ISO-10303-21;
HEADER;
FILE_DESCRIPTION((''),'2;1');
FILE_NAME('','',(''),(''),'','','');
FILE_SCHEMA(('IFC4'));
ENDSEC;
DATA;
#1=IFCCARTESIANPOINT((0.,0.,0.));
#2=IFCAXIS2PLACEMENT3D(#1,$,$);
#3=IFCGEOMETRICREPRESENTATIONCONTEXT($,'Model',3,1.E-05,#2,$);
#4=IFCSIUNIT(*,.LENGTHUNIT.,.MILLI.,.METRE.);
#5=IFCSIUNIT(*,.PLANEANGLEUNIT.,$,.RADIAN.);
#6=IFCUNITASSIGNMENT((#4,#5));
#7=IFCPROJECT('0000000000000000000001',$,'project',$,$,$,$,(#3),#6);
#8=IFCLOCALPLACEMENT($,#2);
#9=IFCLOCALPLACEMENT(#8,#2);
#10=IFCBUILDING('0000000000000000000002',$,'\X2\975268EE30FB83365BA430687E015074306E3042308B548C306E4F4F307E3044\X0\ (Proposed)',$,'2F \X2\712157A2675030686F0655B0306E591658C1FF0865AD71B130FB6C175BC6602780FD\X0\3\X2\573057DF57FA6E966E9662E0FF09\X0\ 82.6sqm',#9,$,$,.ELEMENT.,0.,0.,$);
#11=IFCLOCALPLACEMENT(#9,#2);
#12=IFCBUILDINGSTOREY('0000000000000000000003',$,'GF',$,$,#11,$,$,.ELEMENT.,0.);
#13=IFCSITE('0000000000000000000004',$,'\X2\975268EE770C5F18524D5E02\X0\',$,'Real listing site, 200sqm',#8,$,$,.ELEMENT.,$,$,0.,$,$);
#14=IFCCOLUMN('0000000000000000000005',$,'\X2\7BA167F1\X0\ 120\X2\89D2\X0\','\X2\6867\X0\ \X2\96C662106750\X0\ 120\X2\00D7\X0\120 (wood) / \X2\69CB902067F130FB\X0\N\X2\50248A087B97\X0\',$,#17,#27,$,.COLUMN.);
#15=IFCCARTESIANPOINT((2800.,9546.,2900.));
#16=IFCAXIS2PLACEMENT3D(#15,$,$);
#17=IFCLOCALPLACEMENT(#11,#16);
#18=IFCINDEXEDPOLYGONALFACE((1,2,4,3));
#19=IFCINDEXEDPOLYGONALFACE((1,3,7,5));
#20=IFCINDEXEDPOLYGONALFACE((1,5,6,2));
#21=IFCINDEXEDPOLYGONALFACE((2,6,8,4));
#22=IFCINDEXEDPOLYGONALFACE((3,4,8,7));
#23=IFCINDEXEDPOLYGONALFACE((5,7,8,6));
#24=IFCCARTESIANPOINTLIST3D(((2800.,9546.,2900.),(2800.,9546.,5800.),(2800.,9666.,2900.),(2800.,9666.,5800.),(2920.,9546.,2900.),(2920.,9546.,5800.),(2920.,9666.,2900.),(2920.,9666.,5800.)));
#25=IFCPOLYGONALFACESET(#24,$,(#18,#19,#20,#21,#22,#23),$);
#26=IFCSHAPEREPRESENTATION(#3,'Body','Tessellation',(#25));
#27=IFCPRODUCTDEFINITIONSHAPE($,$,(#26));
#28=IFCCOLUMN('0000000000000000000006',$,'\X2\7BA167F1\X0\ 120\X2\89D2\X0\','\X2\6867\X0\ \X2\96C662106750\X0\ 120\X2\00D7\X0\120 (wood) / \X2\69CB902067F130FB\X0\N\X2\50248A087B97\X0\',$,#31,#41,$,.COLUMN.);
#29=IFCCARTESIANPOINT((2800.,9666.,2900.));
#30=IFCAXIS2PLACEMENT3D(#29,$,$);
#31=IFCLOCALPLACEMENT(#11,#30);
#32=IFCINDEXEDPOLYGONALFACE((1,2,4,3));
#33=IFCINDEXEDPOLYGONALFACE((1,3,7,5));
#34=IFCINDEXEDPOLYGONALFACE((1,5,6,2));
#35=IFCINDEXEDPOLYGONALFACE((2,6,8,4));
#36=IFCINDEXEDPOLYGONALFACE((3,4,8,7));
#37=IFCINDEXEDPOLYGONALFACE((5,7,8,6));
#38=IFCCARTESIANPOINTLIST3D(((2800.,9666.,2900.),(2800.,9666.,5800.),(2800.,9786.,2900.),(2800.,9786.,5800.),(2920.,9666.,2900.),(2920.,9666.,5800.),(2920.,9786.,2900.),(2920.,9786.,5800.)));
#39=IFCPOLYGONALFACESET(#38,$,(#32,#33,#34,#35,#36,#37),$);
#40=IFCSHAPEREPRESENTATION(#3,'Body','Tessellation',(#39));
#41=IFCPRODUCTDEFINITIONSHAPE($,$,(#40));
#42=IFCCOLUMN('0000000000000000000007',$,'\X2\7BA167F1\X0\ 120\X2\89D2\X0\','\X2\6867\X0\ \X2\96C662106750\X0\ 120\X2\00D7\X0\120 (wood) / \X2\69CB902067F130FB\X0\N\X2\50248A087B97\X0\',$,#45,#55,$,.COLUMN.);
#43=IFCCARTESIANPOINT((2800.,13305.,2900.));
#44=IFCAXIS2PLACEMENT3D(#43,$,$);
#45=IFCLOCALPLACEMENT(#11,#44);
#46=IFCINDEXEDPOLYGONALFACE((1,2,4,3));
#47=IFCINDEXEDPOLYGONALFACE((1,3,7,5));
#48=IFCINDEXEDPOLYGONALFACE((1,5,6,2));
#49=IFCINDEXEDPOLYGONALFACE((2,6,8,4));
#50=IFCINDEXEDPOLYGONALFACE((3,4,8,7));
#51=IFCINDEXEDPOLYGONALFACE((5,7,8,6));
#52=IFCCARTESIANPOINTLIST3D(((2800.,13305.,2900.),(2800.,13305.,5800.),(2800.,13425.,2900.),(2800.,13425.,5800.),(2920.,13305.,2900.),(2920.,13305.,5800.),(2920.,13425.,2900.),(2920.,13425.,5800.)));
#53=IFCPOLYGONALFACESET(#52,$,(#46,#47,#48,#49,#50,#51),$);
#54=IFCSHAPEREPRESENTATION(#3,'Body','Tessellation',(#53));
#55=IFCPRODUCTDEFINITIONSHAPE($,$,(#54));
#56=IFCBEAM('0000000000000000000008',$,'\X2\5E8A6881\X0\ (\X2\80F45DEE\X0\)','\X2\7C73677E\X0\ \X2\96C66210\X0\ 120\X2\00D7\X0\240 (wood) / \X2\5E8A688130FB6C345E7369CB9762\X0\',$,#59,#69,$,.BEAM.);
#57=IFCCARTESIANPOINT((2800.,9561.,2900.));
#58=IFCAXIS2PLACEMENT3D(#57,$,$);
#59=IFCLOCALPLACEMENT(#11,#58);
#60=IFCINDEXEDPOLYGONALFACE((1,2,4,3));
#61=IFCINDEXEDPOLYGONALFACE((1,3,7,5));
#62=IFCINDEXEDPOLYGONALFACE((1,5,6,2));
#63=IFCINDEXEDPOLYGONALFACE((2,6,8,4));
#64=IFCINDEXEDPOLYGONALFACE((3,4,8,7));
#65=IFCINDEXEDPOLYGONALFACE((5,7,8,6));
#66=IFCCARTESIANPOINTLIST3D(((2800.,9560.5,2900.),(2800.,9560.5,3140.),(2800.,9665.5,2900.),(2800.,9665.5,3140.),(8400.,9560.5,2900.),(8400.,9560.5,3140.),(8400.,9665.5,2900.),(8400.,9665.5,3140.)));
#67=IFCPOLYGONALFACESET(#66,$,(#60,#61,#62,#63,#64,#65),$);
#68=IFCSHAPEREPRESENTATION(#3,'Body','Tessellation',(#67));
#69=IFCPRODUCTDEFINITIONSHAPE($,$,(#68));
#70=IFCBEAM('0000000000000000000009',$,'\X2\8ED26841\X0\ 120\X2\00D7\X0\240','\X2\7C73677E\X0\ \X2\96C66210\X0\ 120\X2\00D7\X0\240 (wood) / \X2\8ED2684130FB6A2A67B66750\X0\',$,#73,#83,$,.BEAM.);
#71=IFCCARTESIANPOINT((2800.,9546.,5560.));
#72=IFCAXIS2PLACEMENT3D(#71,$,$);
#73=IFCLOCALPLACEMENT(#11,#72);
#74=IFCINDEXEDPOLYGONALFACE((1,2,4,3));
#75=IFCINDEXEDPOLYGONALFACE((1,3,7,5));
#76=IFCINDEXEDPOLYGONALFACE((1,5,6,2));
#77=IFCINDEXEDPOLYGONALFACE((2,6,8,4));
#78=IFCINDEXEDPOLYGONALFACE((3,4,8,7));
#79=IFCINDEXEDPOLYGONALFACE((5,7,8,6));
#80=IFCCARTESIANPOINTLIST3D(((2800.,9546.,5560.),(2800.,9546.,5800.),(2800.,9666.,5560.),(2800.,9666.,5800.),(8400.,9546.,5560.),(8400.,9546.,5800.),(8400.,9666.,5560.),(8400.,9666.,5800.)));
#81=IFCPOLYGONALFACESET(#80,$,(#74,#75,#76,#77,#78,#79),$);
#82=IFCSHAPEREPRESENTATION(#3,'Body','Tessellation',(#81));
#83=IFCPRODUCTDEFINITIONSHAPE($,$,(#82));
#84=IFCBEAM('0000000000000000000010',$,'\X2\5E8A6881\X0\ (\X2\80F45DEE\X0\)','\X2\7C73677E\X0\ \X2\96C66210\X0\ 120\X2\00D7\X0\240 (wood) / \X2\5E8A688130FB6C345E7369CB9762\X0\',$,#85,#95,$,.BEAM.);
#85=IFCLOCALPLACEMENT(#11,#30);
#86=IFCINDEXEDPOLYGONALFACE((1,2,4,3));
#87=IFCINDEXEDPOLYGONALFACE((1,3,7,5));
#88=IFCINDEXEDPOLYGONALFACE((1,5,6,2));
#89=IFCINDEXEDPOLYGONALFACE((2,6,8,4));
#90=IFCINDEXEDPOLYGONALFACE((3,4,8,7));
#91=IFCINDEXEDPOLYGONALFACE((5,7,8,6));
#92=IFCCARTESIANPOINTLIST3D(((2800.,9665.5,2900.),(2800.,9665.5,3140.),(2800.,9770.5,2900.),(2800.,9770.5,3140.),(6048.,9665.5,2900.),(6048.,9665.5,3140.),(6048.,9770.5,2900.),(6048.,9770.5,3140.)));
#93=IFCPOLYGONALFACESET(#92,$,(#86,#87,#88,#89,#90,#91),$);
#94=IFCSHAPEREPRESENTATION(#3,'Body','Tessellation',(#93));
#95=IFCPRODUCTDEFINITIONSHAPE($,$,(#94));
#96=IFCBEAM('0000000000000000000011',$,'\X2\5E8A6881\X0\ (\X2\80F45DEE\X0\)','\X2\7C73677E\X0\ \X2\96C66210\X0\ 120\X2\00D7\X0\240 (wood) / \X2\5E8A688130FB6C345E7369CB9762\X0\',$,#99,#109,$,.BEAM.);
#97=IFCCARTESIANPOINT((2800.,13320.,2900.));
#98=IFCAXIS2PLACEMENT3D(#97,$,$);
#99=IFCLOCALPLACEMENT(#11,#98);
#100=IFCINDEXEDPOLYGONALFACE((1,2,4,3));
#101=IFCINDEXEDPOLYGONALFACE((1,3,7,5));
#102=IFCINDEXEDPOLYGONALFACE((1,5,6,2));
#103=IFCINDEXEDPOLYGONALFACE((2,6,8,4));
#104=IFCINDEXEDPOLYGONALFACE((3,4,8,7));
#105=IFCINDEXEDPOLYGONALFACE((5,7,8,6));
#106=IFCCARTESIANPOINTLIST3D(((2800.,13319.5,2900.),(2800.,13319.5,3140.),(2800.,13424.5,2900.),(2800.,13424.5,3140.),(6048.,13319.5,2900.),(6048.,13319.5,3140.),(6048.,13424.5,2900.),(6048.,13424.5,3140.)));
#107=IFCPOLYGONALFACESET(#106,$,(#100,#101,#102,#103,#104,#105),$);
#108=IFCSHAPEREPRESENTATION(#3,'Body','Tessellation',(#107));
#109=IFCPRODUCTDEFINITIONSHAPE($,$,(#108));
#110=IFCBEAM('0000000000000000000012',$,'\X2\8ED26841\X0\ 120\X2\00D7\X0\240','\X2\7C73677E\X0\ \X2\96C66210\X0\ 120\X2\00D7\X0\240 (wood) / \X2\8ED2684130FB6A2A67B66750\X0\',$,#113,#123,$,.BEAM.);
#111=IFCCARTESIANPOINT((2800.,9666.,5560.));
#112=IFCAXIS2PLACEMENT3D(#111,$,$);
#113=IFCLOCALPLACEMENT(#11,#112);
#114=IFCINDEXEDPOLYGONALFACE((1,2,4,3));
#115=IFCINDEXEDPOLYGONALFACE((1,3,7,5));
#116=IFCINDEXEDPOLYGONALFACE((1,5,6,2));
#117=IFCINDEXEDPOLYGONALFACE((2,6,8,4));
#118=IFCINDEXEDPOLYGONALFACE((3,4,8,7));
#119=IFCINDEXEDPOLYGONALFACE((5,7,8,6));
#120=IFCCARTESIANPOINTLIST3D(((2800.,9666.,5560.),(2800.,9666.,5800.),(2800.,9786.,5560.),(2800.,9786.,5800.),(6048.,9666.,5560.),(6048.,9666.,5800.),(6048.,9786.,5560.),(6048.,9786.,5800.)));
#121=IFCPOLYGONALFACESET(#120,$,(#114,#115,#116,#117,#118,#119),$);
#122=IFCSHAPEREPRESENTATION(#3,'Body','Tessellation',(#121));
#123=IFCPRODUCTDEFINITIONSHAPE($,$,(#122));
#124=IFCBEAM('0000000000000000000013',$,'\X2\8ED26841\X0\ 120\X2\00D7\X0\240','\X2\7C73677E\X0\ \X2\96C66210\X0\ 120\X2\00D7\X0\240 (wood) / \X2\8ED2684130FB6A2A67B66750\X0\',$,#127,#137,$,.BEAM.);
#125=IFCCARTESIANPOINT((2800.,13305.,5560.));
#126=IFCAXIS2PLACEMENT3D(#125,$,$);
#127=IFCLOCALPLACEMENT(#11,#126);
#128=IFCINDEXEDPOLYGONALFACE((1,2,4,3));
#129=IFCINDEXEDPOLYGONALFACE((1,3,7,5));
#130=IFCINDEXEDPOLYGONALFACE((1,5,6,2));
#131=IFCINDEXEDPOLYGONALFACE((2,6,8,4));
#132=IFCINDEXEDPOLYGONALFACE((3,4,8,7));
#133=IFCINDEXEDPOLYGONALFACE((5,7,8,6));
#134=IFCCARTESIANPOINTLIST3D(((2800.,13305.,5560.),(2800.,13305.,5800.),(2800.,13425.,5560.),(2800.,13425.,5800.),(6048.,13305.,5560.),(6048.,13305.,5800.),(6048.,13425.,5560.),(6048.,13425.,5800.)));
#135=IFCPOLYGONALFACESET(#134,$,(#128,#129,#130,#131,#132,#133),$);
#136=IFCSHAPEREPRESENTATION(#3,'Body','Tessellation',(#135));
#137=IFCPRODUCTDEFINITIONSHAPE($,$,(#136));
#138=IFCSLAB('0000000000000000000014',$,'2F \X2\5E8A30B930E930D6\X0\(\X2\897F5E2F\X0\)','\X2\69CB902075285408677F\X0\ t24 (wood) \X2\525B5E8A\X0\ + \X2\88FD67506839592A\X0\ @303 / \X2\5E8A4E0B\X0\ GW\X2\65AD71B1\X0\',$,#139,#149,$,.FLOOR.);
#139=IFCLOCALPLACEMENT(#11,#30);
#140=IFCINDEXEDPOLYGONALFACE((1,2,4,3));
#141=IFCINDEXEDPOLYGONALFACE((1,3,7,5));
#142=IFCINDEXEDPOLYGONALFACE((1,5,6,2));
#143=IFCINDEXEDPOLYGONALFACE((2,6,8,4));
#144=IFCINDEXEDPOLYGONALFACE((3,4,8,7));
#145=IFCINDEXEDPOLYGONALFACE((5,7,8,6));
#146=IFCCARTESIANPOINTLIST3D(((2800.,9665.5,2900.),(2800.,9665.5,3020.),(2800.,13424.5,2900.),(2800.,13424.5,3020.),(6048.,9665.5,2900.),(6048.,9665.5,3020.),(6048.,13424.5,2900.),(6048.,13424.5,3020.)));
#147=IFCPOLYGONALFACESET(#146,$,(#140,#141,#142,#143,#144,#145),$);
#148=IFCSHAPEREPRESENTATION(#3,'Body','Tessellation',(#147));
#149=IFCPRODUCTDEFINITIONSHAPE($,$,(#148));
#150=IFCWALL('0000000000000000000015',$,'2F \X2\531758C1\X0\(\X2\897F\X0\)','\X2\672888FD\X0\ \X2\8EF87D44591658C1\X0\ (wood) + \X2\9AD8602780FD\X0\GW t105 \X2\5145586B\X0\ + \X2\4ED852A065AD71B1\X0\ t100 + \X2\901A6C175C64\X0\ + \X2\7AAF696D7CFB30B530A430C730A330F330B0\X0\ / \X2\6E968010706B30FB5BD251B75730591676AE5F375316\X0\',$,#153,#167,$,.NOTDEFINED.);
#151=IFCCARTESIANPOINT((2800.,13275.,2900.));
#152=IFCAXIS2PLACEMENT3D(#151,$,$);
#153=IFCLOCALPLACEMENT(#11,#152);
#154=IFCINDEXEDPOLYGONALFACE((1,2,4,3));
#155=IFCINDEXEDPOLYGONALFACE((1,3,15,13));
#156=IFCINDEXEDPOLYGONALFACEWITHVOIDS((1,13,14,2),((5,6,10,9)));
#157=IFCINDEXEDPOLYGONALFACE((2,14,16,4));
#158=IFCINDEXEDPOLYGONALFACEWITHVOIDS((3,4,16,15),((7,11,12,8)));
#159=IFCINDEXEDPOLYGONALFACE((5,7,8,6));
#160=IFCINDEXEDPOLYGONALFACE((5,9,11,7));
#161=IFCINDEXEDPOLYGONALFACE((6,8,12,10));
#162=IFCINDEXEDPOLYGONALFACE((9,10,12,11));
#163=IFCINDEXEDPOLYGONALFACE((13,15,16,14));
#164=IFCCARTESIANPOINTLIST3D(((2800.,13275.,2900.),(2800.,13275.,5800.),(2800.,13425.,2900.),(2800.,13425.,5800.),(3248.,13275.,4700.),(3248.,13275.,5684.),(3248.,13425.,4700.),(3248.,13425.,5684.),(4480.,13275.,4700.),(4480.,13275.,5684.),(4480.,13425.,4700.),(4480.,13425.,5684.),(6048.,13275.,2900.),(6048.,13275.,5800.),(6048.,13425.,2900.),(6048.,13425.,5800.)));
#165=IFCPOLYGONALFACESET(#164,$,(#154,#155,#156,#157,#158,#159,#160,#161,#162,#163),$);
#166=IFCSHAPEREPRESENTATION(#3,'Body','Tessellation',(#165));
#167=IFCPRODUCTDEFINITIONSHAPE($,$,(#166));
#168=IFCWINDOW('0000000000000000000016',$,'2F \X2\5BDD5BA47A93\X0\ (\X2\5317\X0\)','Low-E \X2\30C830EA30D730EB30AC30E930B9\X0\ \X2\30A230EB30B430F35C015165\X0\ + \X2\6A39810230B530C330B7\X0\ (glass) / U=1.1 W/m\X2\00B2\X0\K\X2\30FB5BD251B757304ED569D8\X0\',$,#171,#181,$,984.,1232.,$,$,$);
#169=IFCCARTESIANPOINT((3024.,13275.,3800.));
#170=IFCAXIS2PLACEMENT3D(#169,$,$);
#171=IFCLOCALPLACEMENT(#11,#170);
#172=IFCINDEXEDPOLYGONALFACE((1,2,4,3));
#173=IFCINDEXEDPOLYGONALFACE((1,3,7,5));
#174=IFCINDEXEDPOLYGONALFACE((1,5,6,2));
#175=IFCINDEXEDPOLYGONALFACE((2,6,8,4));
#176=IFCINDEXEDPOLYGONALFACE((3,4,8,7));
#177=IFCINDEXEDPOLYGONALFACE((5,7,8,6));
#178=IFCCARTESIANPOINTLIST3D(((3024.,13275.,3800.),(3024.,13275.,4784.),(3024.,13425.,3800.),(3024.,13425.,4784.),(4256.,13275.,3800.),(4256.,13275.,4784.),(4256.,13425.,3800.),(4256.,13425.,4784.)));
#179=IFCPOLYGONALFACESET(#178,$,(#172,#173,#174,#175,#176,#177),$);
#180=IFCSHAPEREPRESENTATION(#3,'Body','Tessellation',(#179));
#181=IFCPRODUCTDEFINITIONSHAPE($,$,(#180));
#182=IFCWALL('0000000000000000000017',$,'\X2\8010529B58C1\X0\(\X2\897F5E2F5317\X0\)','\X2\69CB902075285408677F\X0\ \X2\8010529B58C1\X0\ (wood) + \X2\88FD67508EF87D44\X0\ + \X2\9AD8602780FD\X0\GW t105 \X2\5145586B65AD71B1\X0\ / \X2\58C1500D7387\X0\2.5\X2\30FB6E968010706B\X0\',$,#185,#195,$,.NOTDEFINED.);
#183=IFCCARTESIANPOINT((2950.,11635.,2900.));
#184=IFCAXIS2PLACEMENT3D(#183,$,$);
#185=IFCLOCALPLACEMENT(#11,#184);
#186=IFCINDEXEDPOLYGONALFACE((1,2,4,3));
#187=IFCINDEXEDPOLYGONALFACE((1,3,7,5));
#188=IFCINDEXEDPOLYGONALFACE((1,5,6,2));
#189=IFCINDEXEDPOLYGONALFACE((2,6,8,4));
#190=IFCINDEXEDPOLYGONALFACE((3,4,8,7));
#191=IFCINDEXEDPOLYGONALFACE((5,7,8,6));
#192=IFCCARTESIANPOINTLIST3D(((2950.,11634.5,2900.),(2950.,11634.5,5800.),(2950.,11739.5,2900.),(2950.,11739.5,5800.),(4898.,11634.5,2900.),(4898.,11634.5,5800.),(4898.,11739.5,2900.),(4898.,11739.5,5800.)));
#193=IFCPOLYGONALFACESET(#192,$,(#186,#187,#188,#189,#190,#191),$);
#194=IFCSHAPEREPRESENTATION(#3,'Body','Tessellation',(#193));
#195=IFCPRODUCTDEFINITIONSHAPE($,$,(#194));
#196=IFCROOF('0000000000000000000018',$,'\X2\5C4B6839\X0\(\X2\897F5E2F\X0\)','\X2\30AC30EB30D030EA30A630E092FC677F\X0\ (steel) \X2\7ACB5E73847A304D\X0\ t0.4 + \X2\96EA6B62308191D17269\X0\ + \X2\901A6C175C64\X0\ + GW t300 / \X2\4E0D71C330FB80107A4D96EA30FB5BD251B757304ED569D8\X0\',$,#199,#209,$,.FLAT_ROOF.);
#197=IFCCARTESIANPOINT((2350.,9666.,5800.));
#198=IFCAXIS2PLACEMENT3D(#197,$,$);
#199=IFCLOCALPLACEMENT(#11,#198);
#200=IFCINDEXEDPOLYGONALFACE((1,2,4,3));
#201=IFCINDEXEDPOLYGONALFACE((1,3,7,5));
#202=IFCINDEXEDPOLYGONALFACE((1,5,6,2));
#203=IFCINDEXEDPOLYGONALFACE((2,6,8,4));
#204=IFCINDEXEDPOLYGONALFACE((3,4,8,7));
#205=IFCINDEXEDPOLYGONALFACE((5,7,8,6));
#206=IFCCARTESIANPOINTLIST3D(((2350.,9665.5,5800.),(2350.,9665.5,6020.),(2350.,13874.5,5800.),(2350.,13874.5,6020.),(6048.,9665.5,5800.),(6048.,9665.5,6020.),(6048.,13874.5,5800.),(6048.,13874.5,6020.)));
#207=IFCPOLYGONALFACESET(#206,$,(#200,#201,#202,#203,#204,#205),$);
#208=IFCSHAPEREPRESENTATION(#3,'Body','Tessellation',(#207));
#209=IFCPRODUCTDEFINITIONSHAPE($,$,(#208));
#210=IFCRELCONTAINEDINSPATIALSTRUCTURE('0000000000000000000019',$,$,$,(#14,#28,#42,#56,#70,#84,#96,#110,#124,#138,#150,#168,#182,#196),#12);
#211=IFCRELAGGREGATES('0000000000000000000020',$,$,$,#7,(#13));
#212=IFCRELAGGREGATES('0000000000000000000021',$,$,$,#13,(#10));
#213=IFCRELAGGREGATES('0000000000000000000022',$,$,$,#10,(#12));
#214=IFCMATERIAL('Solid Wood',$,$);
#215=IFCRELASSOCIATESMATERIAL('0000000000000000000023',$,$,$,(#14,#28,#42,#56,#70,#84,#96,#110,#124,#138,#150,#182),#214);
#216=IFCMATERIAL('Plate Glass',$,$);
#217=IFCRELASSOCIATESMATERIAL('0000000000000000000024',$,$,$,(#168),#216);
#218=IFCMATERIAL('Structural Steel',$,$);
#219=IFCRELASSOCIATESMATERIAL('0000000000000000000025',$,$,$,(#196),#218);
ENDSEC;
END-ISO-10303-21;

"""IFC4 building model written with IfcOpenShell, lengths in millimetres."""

from ifc_helpers import new_model, si_unit, frame, frame_2d, origin, place, context, project, spatial, rectangle, extrude, material, element, fill, save


model = new_model("IFC4")

# Units and contexts
model_context = context("Model", 3, precision=1e-05, world=origin())
ifc_project = project(units=[si_unit("LENGTHUNIT", "METRE", prefix="MILLI"), si_unit("PLANEANGLEUNIT", "RADIAN")], contexts=[model_context])

# Site, building, storey
site_placement = place(None, origin())
site = spatial("IfcSite", under=ifc_project, at=site_placement, Name="青森県弘前市", ObjectType="Real listing site, 200sqm", CompositionType="ELEMENT", RefElevation=0.0)
building_placement = place(site_placement, origin())
building = spatial("IfcBuilding", under=site, at=building_placement, Name="青森・茶室と縁側のある和の住まい (Proposed)", ObjectType="2F 無垢材と漆喰の外壁（断熱・気密性能3地域基準準拠） 82.6sqm", CompositionType="ELEMENT", ElevationOfRefHeight=0.0, ElevationOfTerrain=0.0)
storey_placement = place(building_placement, origin())
storey = spatial("IfcBuildingStorey", under=building, at=storey_placement, Name="GF", CompositionType="ELEMENT", Elevation=0.0)

# Columns
ifc_material_1 = material(Name="Solid Wood")
column_1_placement = place(storey_placement, frame((2800.0, 9546.0, 2900.0)))
element("IfcColumn", 1, at=column_1_placement, inside=storey, material=ifc_material_1, Name="管柱 120角", Description="桧 集成材 120×120 (wood) / 構造柱・N値計算", PredefinedType="COLUMN", context=model_context, shape_type="SweptSolid", body=[
    extrude(rectangle(XDim=120.0, YDim=120.0, at=frame_2d((60.0, 60.0))), frame((2800.0, 9546.0, 2900.0)), (0.0, 0.0, 1.0), 2900.0),
])
column_2_placement = place(storey_placement, frame((2800.0, 9666.0, 2900.0)))
element("IfcColumn", 2, at=column_2_placement, inside=storey, material=ifc_material_1, Name="管柱 120角", Description="桧 集成材 120×120 (wood) / 構造柱・N値計算", PredefinedType="COLUMN", context=model_context, shape_type="SweptSolid", body=[
    extrude(rectangle(XDim=120.0, YDim=120.0, at=frame_2d((60.0, 60.0))), frame((2800.0, 9666.0, 2900.0)), (0.0, 0.0, 1.0), 2900.0),
])
column_3_placement = place(storey_placement, frame((2800.0, 13305.0, 2900.0)))
element("IfcColumn", 3, at=column_3_placement, inside=storey, material=ifc_material_1, Name="管柱 120角", Description="桧 集成材 120×120 (wood) / 構造柱・N値計算", PredefinedType="COLUMN", context=model_context, shape_type="SweptSolid", body=[
    extrude(rectangle(XDim=120.0, YDim=120.0, at=frame_2d((60.0, 60.0))), frame((2800.0, 13305.0, 2900.0)), (0.0, 0.0, 1.0), 2900.0),
])

# Beams
beam_1_placement = place(storey_placement, frame((2800.0, 9561.0, 2900.0)))
element("IfcBeam", 4, at=beam_1_placement, inside=storey, material=ifc_material_1, Name="床梁 (胴差)", Description="米松 集成 120×240 (wood) / 床梁・水平構面", PredefinedType="BEAM", context=model_context, shape_type="SweptSolid", body=[
    extrude(rectangle(XDim=5600.0, YDim=105.0, at=frame_2d((2800.0, 52.0))), frame((2800.0, 9561.0, 2900.0)), (0.0, 0.0, 1.0), 240.0),
])
beam_2_placement = place(storey_placement, frame((2800.0, 9546.0, 5560.0)))
element("IfcBeam", 5, at=beam_2_placement, inside=storey, material=ifc_material_1, Name="軒桁 120×240", Description="米松 集成 120×240 (wood) / 軒桁・横架材", PredefinedType="BEAM", context=model_context, shape_type="SweptSolid", body=[
    extrude(rectangle(XDim=5600.0, YDim=120.0, at=frame_2d((2800.0, 60.0))), frame((2800.0, 9546.0, 5560.0)), (0.0, 0.0, 1.0), 240.0),
])
beam_3_placement = place(storey_placement, frame((2800.0, 9666.0, 2900.0)))
element("IfcBeam", 6, at=beam_3_placement, inside=storey, material=ifc_material_1, Name="床梁 (胴差)", Description="米松 集成 120×240 (wood) / 床梁・水平構面", PredefinedType="BEAM", context=model_context, shape_type="SweptSolid", body=[
    extrude(rectangle(XDim=3248.0, YDim=105.0, at=frame_2d((1624.0, 52.0))), frame((2800.0, 9666.0, 2900.0)), (0.0, 0.0, 1.0), 240.0),
])
beam_4_placement = place(storey_placement, frame((2800.0, 13320.0, 2900.0)))
element("IfcBeam", 7, at=beam_4_placement, inside=storey, material=ifc_material_1, Name="床梁 (胴差)", Description="米松 集成 120×240 (wood) / 床梁・水平構面", PredefinedType="BEAM", context=model_context, shape_type="SweptSolid", body=[
    extrude(rectangle(XDim=3248.0, YDim=105.0, at=frame_2d((1624.0, 52.0))), frame((2800.0, 13320.0, 2900.0)), (0.0, 0.0, 1.0), 240.0),
])
beam_5_placement = place(storey_placement, frame((2800.0, 9666.0, 5560.0)))
element("IfcBeam", 8, at=beam_5_placement, inside=storey, material=ifc_material_1, Name="軒桁 120×240", Description="米松 集成 120×240 (wood) / 軒桁・横架材", PredefinedType="BEAM", context=model_context, shape_type="SweptSolid", body=[
    extrude(rectangle(XDim=3248.0, YDim=120.0, at=frame_2d((1624.0, 60.0))), frame((2800.0, 9666.0, 5560.0)), (0.0, 0.0, 1.0), 240.0),
])
beam_6_placement = place(storey_placement, frame((2800.0, 13305.0, 5560.0)))
element("IfcBeam", 9, at=beam_6_placement, inside=storey, material=ifc_material_1, Name="軒桁 120×240", Description="米松 集成 120×240 (wood) / 軒桁・横架材", PredefinedType="BEAM", context=model_context, shape_type="SweptSolid", body=[
    extrude(rectangle(XDim=3248.0, YDim=120.0, at=frame_2d((1624.0, 60.0))), frame((2800.0, 13305.0, 5560.0)), (0.0, 0.0, 1.0), 240.0),
])

# Slab
slab_placement = place(storey_placement, frame((2800.0, 9666.0, 2900.0)))
element("IfcSlab", 10, at=slab_placement, inside=storey, material=ifc_material_1, Name="2F 床スラブ(西帯)", Description="構造用合板 t24 (wood) 剛床 + 製材根太 @303 / 床下 GW断熱", PredefinedType="FLOOR", context=model_context, shape_type="SweptSolid", body=[
    extrude(rectangle(XDim=3248.0, YDim=3759.0, at=frame_2d((1624.0, 1879.0))), frame((2800.0, 9666.0, 2900.0)), (0.0, 0.0, 1.0), 120.0),
])

# Wall, opening, window
wall_1_placement = place(storey_placement, frame((2800.0, 13275.0, 2900.0)))
wall_1 = element("IfcWall", 11, at=wall_1_placement, inside=storey, material=ifc_material_1, Name="2F 北壁(西)", Description="木製 軸組外壁 (wood) + 高性能GW t105 充填 + 付加断熱 t100 + 通気層 + 窯業系サイディング / 準耐火・寒冷地外皮強化", PredefinedType="NOTDEFINED", context=model_context, shape_type="SweptSolid", body=[
    extrude(rectangle(XDim=3248.0, YDim=150.0, at=frame_2d((1624.0, 75.0))), frame((2800.0, 13275.0, 2900.0)), (0.0, 0.0, 1.0), 2900.0),
])
opening_placement = place(storey_placement, frame((3024.0, 13275.0, 3800.0)))
opening = element("IfcOpeningElement", 12, at=opening_placement, cuts=wall_1, PredefinedType="NOTDEFINED", context=model_context, shape_type="SweptSolid", body=[
    extrude(rectangle(XDim=1232.0, YDim=150.0, at=frame_2d((616.0, 75.0))), frame((3024.0, 13275.0, 3800.0)), (0.0, 0.0, 1.0), 984.0),
])
ifc_material_2 = material(Name="Plate Glass")
window_placement = place(storey_placement, frame((3024.0, 13275.0, 3800.0)))
window = element("IfcWindow", 13, at=window_placement, inside=storey, material=ifc_material_2, Name="2F 寝室窓 (北)", Description="Low-E トリプルガラス アルゴン封入 + 樹脂サッシ (glass) / U=1.1 W/m²K・寒冷地仕様", OverallHeight=984.0, OverallWidth=1232.0, context=model_context, shape_type="SweptSolid", body=[
    extrude(rectangle(XDim=1232.0, YDim=150.0, at=frame_2d((616.0, 75.0))), frame((3024.0, 13275.0, 3800.0)), (0.0, 0.0, 1.0), 984.0),
])
fill(opening, window)

# Wall
wall_2_placement = place(storey_placement, frame((2950.0, 11635.0, 2900.0)))
element("IfcWall", 14, at=wall_2_placement, inside=storey, material=ifc_material_1, Name="耐力壁(西帯北)", Description="構造用合板 耐力壁 (wood) + 製材軸組 + 高性能GW t105 充填断熱 / 壁倍率2.5・準耐火", PredefinedType="NOTDEFINED", context=model_context, shape_type="SweptSolid", body=[
    extrude(rectangle(XDim=1948.0, YDim=105.0, at=frame_2d((974.0, 52.0))), frame((2950.0, 11635.0, 2900.0)), (0.0, 0.0, 1.0), 2900.0),
])

# Roof
ifc_material_3 = material(Name="Structural Steel")
for number, where, name in (
    (15, (2350.0, 9666.0, 5800.0), "屋根(西帯)"),
):
    element("IfcRoof", number, at=place(storey_placement, frame(where)), inside=storey, material=ifc_material_3, Name=name, Description="ガルバリウム鋼板 (steel) 立平葺き t0.4 + 雪止め金物 + 通気層 + GW t300 / 不燃・耐積雪・寒冷地仕様", PredefinedType="FLAT_ROOF", context=model_context, shape_type="SweptSolid", body=[
        extrude(rectangle(XDim=3698.0, YDim=4209.0, at=frame_2d((1849.0, 2104.0))), frame((2350.0, 9666.0, 5800.0)), (0.0, 0.0, 1.0), 220.0),
    ])

save(model, "model.ifc")
